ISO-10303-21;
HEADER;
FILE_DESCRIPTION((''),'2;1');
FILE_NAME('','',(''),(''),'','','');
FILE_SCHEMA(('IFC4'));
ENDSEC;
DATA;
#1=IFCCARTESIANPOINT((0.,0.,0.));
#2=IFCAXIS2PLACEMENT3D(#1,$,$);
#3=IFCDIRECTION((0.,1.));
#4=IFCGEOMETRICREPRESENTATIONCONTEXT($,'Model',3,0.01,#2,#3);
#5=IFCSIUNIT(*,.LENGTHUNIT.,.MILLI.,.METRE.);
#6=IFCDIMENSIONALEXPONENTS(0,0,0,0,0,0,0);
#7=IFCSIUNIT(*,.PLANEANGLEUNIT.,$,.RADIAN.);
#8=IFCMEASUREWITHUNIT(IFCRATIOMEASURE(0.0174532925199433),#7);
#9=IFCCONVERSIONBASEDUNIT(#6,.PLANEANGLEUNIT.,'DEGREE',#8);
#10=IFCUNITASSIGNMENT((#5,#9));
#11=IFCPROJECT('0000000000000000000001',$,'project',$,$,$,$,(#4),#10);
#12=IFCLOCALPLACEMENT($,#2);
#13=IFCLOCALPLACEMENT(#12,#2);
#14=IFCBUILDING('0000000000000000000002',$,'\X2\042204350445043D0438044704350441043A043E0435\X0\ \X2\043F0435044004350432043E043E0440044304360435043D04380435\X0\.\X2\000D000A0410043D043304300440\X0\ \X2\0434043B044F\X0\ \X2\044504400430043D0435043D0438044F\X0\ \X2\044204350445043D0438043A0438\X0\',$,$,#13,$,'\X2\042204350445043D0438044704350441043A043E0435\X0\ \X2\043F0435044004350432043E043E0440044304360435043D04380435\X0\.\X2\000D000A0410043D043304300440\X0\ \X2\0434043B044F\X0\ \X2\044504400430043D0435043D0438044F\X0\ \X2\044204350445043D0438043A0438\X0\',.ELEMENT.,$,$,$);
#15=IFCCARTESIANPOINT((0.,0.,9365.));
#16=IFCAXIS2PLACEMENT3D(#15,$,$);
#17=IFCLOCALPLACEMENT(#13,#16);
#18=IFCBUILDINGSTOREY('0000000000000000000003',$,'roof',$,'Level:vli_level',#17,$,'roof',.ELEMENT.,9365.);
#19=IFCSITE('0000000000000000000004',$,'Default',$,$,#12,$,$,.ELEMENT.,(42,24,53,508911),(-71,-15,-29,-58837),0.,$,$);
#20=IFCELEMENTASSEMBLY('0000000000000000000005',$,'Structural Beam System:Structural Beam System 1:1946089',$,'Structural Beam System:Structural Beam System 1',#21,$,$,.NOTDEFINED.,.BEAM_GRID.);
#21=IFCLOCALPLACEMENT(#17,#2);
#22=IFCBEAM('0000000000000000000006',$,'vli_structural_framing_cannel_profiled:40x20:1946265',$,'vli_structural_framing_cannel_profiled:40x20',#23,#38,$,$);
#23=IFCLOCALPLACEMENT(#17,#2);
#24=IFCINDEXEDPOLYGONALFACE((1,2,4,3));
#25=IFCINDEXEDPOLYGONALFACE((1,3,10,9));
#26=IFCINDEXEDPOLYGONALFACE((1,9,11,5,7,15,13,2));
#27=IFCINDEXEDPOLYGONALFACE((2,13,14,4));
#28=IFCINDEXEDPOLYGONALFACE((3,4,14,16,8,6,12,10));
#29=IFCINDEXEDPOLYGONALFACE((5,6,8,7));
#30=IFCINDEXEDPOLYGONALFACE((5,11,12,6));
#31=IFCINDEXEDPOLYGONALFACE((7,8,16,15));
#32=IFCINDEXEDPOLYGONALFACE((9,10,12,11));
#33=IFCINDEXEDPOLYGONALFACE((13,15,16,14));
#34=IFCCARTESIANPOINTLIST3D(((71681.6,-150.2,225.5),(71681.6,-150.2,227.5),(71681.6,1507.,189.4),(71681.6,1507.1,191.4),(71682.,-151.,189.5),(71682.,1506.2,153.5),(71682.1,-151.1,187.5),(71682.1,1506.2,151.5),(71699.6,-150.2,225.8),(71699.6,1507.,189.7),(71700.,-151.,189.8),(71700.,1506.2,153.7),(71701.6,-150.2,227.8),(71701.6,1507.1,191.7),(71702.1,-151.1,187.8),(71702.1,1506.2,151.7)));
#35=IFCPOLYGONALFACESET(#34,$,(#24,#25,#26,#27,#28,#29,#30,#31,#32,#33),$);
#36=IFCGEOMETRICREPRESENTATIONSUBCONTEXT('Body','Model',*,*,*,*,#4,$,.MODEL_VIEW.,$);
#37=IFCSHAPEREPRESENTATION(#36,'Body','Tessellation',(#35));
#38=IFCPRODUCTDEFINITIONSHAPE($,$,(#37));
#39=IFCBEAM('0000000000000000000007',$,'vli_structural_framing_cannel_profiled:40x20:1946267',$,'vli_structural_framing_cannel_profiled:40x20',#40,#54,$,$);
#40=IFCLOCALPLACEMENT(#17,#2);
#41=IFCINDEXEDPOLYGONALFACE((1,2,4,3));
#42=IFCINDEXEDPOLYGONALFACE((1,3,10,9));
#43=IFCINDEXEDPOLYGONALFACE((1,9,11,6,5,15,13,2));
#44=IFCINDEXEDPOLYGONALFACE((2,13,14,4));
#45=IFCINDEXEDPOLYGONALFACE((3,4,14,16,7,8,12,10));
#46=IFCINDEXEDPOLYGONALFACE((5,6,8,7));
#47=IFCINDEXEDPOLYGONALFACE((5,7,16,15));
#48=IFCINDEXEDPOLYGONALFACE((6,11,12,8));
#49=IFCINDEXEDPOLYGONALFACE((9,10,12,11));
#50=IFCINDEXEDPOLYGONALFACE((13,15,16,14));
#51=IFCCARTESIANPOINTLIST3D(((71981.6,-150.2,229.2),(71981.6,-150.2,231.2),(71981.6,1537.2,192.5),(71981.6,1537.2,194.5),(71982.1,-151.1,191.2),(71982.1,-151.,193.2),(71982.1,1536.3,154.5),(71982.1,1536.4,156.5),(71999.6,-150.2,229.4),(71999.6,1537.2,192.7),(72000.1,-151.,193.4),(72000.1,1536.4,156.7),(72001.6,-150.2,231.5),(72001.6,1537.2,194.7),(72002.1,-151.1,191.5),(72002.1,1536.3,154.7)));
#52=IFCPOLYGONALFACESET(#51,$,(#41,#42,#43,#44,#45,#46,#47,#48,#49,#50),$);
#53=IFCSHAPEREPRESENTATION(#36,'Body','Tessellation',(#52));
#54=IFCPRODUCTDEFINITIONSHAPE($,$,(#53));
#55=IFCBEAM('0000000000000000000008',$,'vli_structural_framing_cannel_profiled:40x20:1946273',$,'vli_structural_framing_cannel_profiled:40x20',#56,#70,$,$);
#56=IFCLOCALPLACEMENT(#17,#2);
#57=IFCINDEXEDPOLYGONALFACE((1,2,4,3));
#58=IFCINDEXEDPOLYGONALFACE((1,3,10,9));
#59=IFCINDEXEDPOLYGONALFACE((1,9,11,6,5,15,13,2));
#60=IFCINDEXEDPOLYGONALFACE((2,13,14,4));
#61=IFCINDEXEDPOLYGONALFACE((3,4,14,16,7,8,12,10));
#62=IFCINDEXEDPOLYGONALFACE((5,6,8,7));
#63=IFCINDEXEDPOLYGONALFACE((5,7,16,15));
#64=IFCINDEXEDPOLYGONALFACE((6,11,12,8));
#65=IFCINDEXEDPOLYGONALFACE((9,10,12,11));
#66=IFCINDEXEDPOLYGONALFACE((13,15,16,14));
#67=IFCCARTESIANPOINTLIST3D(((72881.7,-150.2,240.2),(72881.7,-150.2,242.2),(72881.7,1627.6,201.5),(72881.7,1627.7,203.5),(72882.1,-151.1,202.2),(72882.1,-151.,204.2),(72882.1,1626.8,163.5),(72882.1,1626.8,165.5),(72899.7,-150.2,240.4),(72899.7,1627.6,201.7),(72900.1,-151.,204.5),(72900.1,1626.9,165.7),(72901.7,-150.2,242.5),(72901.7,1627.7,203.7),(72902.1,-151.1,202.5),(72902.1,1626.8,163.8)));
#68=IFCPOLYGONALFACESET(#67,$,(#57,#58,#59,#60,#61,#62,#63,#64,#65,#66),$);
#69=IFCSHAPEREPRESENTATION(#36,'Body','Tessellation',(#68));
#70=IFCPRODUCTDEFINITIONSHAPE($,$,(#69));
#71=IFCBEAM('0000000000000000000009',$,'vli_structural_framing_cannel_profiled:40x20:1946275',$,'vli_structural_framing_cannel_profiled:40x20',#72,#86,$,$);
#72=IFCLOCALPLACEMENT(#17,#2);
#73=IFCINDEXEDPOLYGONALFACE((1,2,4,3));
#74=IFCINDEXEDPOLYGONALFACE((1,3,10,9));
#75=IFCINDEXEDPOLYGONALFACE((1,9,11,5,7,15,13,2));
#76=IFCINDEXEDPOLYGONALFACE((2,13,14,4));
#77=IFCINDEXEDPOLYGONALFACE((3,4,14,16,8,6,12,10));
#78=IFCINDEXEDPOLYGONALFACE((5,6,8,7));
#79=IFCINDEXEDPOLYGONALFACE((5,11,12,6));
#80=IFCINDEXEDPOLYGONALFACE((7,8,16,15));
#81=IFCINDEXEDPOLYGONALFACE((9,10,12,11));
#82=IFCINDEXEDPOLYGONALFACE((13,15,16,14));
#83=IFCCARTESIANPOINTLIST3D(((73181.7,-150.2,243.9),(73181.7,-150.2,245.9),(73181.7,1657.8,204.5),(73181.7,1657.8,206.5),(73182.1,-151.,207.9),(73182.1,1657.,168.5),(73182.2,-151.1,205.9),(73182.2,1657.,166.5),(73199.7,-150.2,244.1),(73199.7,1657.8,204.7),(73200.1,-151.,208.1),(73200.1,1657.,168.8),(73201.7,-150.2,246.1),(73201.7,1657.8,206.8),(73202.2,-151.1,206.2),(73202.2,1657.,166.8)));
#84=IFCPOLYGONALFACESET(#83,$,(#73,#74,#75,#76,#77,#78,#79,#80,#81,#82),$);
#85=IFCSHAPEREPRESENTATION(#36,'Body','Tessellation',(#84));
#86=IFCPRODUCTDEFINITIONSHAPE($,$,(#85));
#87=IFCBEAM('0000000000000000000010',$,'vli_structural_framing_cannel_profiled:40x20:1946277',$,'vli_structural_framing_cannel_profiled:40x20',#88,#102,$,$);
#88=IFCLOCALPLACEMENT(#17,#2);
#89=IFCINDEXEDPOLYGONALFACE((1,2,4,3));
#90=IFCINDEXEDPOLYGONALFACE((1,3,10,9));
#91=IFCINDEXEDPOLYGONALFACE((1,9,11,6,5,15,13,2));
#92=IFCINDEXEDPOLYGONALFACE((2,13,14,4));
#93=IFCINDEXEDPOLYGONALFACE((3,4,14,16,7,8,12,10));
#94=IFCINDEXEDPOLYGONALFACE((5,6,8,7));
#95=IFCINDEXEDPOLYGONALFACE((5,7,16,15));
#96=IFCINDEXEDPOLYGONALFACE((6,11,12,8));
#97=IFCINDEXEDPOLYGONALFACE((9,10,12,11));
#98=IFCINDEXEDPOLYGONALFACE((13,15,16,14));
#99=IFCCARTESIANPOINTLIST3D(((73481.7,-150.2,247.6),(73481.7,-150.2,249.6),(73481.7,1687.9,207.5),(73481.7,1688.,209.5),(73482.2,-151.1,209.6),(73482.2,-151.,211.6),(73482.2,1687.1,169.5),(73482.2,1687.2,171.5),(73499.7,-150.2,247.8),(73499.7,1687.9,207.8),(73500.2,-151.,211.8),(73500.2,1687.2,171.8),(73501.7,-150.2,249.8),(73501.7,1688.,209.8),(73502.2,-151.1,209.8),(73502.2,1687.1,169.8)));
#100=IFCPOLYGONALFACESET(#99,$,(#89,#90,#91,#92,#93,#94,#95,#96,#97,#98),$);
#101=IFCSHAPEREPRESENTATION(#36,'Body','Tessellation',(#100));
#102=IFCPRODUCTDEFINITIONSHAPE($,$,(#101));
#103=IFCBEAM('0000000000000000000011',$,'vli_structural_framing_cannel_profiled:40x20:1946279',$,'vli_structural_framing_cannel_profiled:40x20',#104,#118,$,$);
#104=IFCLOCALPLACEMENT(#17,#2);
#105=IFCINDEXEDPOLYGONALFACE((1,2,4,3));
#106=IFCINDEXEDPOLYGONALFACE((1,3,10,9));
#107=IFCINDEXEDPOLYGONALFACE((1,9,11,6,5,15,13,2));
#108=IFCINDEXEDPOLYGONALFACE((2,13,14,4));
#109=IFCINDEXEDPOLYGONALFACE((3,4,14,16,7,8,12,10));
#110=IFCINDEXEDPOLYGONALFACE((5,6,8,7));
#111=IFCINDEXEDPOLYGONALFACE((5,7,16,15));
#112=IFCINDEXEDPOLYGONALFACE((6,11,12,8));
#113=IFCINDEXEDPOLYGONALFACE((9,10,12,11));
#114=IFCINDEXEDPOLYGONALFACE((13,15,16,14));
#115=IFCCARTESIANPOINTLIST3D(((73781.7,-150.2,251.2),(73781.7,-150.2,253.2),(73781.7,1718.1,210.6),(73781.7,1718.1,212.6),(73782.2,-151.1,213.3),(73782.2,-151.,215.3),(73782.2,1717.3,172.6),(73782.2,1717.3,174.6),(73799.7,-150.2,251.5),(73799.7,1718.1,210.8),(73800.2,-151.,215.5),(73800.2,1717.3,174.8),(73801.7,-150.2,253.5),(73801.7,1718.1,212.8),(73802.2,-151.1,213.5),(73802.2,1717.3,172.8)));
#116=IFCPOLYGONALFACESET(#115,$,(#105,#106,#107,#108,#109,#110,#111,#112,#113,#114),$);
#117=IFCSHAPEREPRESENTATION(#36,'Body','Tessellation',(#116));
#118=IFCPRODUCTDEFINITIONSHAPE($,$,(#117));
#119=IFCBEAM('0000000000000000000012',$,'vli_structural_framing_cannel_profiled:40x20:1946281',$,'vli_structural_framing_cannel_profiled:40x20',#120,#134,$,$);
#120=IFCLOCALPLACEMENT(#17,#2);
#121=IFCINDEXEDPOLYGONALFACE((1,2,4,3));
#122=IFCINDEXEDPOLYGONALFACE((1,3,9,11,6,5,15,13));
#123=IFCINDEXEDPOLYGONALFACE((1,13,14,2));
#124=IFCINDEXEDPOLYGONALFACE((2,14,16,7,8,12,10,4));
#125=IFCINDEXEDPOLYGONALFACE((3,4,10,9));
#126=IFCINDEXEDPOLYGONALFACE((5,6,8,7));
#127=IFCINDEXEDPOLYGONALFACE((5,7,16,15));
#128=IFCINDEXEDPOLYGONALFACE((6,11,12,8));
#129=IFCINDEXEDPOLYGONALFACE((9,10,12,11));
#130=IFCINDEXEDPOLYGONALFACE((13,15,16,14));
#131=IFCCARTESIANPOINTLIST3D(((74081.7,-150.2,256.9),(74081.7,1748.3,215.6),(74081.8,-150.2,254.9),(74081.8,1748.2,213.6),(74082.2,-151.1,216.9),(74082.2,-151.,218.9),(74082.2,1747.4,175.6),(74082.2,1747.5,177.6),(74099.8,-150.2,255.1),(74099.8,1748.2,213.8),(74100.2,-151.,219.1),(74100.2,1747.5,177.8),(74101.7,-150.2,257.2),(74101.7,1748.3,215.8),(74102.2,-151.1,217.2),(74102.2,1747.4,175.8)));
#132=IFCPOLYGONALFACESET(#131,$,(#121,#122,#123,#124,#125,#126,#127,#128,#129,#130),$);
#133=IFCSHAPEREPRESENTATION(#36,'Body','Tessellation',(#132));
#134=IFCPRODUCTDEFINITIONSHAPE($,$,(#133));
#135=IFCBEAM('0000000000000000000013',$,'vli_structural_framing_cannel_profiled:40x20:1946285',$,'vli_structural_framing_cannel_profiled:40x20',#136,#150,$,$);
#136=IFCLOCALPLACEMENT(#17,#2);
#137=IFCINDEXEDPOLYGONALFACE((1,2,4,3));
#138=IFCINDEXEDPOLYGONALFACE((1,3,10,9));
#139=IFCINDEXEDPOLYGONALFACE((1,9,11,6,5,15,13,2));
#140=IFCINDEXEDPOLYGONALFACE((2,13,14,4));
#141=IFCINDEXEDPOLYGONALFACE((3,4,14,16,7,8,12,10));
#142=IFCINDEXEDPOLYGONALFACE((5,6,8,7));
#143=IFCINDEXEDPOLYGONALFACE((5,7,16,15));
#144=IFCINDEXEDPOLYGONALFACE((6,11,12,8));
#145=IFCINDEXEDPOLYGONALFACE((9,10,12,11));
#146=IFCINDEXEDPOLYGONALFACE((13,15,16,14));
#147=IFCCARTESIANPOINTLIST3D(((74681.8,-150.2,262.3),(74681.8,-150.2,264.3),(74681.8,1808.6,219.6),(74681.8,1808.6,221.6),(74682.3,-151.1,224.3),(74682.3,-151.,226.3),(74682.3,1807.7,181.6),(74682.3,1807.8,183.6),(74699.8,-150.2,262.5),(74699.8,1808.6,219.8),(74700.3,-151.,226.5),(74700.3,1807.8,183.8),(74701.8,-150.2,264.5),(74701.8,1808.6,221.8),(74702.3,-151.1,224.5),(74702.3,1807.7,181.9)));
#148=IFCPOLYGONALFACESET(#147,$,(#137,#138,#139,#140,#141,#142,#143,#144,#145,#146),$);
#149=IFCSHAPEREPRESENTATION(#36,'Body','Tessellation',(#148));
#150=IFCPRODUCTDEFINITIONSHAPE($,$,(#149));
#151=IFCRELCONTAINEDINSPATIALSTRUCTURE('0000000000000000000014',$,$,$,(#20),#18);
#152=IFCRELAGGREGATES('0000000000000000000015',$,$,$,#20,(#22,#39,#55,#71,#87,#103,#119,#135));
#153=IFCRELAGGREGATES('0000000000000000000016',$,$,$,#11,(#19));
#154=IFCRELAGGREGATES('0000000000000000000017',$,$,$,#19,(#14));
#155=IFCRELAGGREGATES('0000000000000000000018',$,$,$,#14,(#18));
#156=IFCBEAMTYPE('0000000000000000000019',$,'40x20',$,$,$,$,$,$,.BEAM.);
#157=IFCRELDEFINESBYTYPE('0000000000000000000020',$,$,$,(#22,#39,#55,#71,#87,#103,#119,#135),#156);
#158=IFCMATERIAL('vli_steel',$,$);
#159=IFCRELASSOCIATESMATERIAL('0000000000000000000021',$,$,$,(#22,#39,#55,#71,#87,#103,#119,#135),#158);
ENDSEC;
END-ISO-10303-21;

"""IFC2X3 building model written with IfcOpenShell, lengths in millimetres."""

from ifc_helpers import new_model, entity, si_unit, converted_unit, direction, frame, origin, place, context, subcontext, project, spatial, polyline, outline, extrude, material, type_object, element, aggregate, save


model = new_model("IFC2X3")

# Units and contexts
model_context = context("Model", 3, precision=0.01, world=origin(), true_north=direction((0.0, 1.0)))
body_context = subcontext(model_context, "Body", "Model", "MODEL_VIEW")
ifc_project = project(units=[si_unit("LENGTHUNIT", "METRE", prefix="MILLI"), converted_unit("PLANEANGLEUNIT", "DEGREE", entity("IfcRatioMeasure", 0.0174532925199433), si_unit("PLANEANGLEUNIT", "RADIAN"), dimensions=[0, 0, 0, 0, 0, 0, 0])], contexts=[model_context])

# Site, building, storey
site_placement = place(None, origin())
site = spatial("IfcSite", under=ifc_project, at=site_placement, Name="Default", CompositionType="ELEMENT", RefLatitude=(42, 24, 53, 508911), RefLongitude=(-71, -15, -29, -58837), RefElevation=0.0)
building_placement = place(site_placement, origin())
building = spatial("IfcBuilding", under=site, at=building_placement, Name="Техническое перевооружение.\r\nАнгар для хранения техники", LongName="Техническое перевооружение.\r\nАнгар для хранения техники", CompositionType="ELEMENT")
storey_placement = place(building_placement, frame((0.0, 0.0, 9365.0)))
storey = spatial("IfcBuildingStorey", under=building, at=storey_placement, Name="roof", ObjectType="Level:vli_level", LongName="roof", CompositionType="ELEMENT", Elevation=9365.0)

# Element assembly, beams
ifc_material = material(Name="vli_steel")
beam_type = type_object("IfcBeamType", Name="40x20", PredefinedType="BEAM")
assembly_1_placement = place(storey_placement, origin())
assembly_1 = element("IfcElementAssembly", 1, at=assembly_1_placement, inside=storey, Name="Structural Beam System:Structural Beam System 1:1946089", ObjectType="Structural Beam System:Structural Beam System 1", AssemblyPlace="NOTDEFINED", PredefinedType="BEAM_GRID")
beam_1_placement = place(assembly_1_placement, frame((71701.0, 1507.1, 191.7), z_axis=(0.0, 0.021775, 0.999763), x_axis=(0.0, -0.999763, 0.021775)))
beam_1 = element("IfcBeam", 2, at=beam_1_placement, type_object=beam_type, material=ifc_material, Name="vli_structural_framing_cannel_profiled:40x20:1946265", ObjectType="vli_structural_framing_cannel_profiled:40x20", context=body_context, shape_type="SweptSolid", body=[
    extrude(outline(polyline([(-10.5, -20.0), (9.5, -20.0), (9.5, -18.0), (-8.5, -18.0), (-8.5, 18.0), (9.5, 18.0), (9.5, 20.0), (-10.5, 20.0), (-10.5, -20.0)])), frame((0.0, -9.7, -20.1), z_axis=(1.0, 0.0, 0.0), x_axis=(0.0, -0.999925, -0.01227)), (0.0, 0.0, 1.0), 1657.6),
])
beam_2_placement = place(assembly_1_placement, frame((72001.0, 1537.2, 194.7), z_axis=(0.0, 0.021775, 0.999763), x_axis=(0.0, -0.999763, 0.021775)))
beam_2 = element("IfcBeam", 3, at=beam_2_placement, type_object=beam_type, material=ifc_material, Name="vli_structural_framing_cannel_profiled:40x20:1946267", ObjectType="vli_structural_framing_cannel_profiled:40x20", context=body_context, shape_type="SweptSolid", body=[
    extrude(outline(polyline([(-10.5, -20.0), (9.5, -20.0), (9.5, -18.0), (-8.5, -18.0), (-8.5, 18.0), (9.5, 18.0), (9.5, 20.0), (-10.5, 20.0), (-10.5, -20.0)])), frame((0.0, -9.7, -20.1), z_axis=(1.0, 0.0, 0.0), x_axis=(0.0, -0.999925, -0.01227)), (0.0, 0.0, 1.0), 1687.8),
])
beam_3_placement = place(assembly_1_placement, frame((72901.1, 1627.7, 203.7), z_axis=(0.0, 0.021775, 0.999763), x_axis=(0.0, -0.999763, 0.021775)))
beam_3 = element("IfcBeam", 4, at=beam_3_placement, type_object=beam_type, material=ifc_material, Name="vli_structural_framing_cannel_profiled:40x20:1946273", ObjectType="vli_structural_framing_cannel_profiled:40x20", context=body_context, shape_type="SweptSolid", body=[
    extrude(outline(polyline([(-10.5, -20.0), (9.5, -20.0), (9.5, -18.0), (-8.5, -18.0), (-8.5, 18.0), (9.5, 18.0), (9.5, 20.0), (-10.5, 20.0), (-10.5, -20.0)])), frame((0.0, -9.7, -20.1), z_axis=(1.0, 0.0, 0.0), x_axis=(0.0, -0.999925, -0.01227)), (0.0, 0.0, 1.0), 1778.3),
])
beam_4_placement = place(assembly_1_placement, frame((73201.1, 1657.8, 206.8), z_axis=(0.0, 0.021775, 0.999763), x_axis=(0.0, -0.999763, 0.021775)))
beam_4 = element("IfcBeam", 5, at=beam_4_placement, type_object=beam_type, material=ifc_material, Name="vli_structural_framing_cannel_profiled:40x20:1946275", ObjectType="vli_structural_framing_cannel_profiled:40x20", context=body_context, shape_type="SweptSolid", body=[
    extrude(outline(polyline([(-10.5, -20.0), (9.5, -20.0), (9.5, -18.0), (-8.5, -18.0), (-8.5, 18.0), (9.5, 18.0), (9.5, 20.0), (-10.5, 20.0), (-10.5, -20.0)])), frame((0.0, -9.7, -20.1), z_axis=(1.0, 0.0, 0.0), x_axis=(0.0, -0.999925, -0.01227)), (0.0, 0.0, 1.0), 1808.4),
])
beam_5_placement = place(assembly_1_placement, frame((73501.1, 1688.0, 209.8), z_axis=(0.0, 0.021775, 0.999763), x_axis=(0.0, -0.999763, 0.021775)))
beam_5 = element("IfcBeam", 6, at=beam_5_placement, type_object=beam_type, material=ifc_material, Name="vli_structural_framing_cannel_profiled:40x20:1946277", ObjectType="vli_structural_framing_cannel_profiled:40x20", context=body_context, shape_type="SweptSolid", body=[
    extrude(outline(polyline([(-10.5, -20.0), (9.5, -20.0), (9.5, -18.0), (-8.5, -18.0), (-8.5, 18.0), (9.5, 18.0), (9.5, 20.0), (-10.5, 20.0), (-10.5, -20.0)])), frame((0.0, -9.7, -20.1), z_axis=(1.0, 0.0, 0.0), x_axis=(0.0, -0.999925, -0.01227)), (0.0, 0.0, 1.0), 1838.6),
])
beam_6_placement = place(assembly_1_placement, frame((73801.1, 1718.1, 212.8), z_axis=(0.0, 0.021775, 0.999763), x_axis=(0.0, -0.999763, 0.021775)))
beam_6 = element("IfcBeam", 7, at=beam_6_placement, type_object=beam_type, material=ifc_material, Name="vli_structural_framing_cannel_profiled:40x20:1946279", ObjectType="vli_structural_framing_cannel_profiled:40x20", context=body_context, shape_type="SweptSolid", body=[
    extrude(outline(polyline([(-10.5, -20.0), (9.5, -20.0), (9.5, -18.0), (-8.5, -18.0), (-8.5, 18.0), (9.5, 18.0), (9.5, 20.0), (-10.5, 20.0), (-10.5, -20.0)])), frame((0.0, -9.7, -20.1), z_axis=(1.0, 0.0, 0.0), x_axis=(0.0, -0.999925, -0.01227)), (0.0, 0.0, 1.0), 1868.8),
])
beam_7_placement = place(assembly_1_placement, frame((74101.1, 1748.3, 215.8), z_axis=(0.0, 0.021775, 0.999763), x_axis=(0.0, -0.999763, 0.021775)))
beam_7 = element("IfcBeam", 8, at=beam_7_placement, type_object=beam_type, material=ifc_material, Name="vli_structural_framing_cannel_profiled:40x20:1946281", ObjectType="vli_structural_framing_cannel_profiled:40x20", context=body_context, shape_type="SweptSolid", body=[
    extrude(outline(polyline([(-10.5, -20.0), (9.5, -20.0), (9.5, -18.0), (-8.5, -18.0), (-8.5, 18.0), (9.5, 18.0), (9.5, 20.0), (-10.5, 20.0), (-10.5, -20.0)])), frame((0.0, -9.7, -20.1), z_axis=(1.0, 0.0, 0.0), x_axis=(0.0, -0.999925, -0.01227)), (0.0, 0.0, 1.0), 1898.9),
])
beam_8_placement = place(assembly_1_placement, frame((74701.2, 1808.6, 221.8), z_axis=(0.0, 0.021775, 0.999763), x_axis=(0.0, -0.999763, 0.021775)))
beam_8 = element("IfcBeam", 9, at=beam_8_placement, type_object=beam_type, material=ifc_material, Name="vli_structural_framing_cannel_profiled:40x20:1946285", ObjectType="vli_structural_framing_cannel_profiled:40x20", context=body_context, shape_type="SweptSolid", body=[
    extrude(outline(polyline([(-10.5, -20.0), (9.5, -20.0), (9.5, -18.0), (-8.5, -18.0), (-8.5, 18.0), (9.5, 18.0), (9.5, 20.0), (-10.5, 20.0), (-10.5, -20.0)])), frame((0.0, -9.7, -20.1), z_axis=(1.0, 0.0, 0.0), x_axis=(0.0, -0.999925, -0.01227)), (0.0, 0.0, 1.0), 1959.3),
])
aggregate(assembly_1, [beam_1, beam_2, beam_3, beam_4, beam_5, beam_6, beam_7, beam_8])

save(model, "model.ifc")
